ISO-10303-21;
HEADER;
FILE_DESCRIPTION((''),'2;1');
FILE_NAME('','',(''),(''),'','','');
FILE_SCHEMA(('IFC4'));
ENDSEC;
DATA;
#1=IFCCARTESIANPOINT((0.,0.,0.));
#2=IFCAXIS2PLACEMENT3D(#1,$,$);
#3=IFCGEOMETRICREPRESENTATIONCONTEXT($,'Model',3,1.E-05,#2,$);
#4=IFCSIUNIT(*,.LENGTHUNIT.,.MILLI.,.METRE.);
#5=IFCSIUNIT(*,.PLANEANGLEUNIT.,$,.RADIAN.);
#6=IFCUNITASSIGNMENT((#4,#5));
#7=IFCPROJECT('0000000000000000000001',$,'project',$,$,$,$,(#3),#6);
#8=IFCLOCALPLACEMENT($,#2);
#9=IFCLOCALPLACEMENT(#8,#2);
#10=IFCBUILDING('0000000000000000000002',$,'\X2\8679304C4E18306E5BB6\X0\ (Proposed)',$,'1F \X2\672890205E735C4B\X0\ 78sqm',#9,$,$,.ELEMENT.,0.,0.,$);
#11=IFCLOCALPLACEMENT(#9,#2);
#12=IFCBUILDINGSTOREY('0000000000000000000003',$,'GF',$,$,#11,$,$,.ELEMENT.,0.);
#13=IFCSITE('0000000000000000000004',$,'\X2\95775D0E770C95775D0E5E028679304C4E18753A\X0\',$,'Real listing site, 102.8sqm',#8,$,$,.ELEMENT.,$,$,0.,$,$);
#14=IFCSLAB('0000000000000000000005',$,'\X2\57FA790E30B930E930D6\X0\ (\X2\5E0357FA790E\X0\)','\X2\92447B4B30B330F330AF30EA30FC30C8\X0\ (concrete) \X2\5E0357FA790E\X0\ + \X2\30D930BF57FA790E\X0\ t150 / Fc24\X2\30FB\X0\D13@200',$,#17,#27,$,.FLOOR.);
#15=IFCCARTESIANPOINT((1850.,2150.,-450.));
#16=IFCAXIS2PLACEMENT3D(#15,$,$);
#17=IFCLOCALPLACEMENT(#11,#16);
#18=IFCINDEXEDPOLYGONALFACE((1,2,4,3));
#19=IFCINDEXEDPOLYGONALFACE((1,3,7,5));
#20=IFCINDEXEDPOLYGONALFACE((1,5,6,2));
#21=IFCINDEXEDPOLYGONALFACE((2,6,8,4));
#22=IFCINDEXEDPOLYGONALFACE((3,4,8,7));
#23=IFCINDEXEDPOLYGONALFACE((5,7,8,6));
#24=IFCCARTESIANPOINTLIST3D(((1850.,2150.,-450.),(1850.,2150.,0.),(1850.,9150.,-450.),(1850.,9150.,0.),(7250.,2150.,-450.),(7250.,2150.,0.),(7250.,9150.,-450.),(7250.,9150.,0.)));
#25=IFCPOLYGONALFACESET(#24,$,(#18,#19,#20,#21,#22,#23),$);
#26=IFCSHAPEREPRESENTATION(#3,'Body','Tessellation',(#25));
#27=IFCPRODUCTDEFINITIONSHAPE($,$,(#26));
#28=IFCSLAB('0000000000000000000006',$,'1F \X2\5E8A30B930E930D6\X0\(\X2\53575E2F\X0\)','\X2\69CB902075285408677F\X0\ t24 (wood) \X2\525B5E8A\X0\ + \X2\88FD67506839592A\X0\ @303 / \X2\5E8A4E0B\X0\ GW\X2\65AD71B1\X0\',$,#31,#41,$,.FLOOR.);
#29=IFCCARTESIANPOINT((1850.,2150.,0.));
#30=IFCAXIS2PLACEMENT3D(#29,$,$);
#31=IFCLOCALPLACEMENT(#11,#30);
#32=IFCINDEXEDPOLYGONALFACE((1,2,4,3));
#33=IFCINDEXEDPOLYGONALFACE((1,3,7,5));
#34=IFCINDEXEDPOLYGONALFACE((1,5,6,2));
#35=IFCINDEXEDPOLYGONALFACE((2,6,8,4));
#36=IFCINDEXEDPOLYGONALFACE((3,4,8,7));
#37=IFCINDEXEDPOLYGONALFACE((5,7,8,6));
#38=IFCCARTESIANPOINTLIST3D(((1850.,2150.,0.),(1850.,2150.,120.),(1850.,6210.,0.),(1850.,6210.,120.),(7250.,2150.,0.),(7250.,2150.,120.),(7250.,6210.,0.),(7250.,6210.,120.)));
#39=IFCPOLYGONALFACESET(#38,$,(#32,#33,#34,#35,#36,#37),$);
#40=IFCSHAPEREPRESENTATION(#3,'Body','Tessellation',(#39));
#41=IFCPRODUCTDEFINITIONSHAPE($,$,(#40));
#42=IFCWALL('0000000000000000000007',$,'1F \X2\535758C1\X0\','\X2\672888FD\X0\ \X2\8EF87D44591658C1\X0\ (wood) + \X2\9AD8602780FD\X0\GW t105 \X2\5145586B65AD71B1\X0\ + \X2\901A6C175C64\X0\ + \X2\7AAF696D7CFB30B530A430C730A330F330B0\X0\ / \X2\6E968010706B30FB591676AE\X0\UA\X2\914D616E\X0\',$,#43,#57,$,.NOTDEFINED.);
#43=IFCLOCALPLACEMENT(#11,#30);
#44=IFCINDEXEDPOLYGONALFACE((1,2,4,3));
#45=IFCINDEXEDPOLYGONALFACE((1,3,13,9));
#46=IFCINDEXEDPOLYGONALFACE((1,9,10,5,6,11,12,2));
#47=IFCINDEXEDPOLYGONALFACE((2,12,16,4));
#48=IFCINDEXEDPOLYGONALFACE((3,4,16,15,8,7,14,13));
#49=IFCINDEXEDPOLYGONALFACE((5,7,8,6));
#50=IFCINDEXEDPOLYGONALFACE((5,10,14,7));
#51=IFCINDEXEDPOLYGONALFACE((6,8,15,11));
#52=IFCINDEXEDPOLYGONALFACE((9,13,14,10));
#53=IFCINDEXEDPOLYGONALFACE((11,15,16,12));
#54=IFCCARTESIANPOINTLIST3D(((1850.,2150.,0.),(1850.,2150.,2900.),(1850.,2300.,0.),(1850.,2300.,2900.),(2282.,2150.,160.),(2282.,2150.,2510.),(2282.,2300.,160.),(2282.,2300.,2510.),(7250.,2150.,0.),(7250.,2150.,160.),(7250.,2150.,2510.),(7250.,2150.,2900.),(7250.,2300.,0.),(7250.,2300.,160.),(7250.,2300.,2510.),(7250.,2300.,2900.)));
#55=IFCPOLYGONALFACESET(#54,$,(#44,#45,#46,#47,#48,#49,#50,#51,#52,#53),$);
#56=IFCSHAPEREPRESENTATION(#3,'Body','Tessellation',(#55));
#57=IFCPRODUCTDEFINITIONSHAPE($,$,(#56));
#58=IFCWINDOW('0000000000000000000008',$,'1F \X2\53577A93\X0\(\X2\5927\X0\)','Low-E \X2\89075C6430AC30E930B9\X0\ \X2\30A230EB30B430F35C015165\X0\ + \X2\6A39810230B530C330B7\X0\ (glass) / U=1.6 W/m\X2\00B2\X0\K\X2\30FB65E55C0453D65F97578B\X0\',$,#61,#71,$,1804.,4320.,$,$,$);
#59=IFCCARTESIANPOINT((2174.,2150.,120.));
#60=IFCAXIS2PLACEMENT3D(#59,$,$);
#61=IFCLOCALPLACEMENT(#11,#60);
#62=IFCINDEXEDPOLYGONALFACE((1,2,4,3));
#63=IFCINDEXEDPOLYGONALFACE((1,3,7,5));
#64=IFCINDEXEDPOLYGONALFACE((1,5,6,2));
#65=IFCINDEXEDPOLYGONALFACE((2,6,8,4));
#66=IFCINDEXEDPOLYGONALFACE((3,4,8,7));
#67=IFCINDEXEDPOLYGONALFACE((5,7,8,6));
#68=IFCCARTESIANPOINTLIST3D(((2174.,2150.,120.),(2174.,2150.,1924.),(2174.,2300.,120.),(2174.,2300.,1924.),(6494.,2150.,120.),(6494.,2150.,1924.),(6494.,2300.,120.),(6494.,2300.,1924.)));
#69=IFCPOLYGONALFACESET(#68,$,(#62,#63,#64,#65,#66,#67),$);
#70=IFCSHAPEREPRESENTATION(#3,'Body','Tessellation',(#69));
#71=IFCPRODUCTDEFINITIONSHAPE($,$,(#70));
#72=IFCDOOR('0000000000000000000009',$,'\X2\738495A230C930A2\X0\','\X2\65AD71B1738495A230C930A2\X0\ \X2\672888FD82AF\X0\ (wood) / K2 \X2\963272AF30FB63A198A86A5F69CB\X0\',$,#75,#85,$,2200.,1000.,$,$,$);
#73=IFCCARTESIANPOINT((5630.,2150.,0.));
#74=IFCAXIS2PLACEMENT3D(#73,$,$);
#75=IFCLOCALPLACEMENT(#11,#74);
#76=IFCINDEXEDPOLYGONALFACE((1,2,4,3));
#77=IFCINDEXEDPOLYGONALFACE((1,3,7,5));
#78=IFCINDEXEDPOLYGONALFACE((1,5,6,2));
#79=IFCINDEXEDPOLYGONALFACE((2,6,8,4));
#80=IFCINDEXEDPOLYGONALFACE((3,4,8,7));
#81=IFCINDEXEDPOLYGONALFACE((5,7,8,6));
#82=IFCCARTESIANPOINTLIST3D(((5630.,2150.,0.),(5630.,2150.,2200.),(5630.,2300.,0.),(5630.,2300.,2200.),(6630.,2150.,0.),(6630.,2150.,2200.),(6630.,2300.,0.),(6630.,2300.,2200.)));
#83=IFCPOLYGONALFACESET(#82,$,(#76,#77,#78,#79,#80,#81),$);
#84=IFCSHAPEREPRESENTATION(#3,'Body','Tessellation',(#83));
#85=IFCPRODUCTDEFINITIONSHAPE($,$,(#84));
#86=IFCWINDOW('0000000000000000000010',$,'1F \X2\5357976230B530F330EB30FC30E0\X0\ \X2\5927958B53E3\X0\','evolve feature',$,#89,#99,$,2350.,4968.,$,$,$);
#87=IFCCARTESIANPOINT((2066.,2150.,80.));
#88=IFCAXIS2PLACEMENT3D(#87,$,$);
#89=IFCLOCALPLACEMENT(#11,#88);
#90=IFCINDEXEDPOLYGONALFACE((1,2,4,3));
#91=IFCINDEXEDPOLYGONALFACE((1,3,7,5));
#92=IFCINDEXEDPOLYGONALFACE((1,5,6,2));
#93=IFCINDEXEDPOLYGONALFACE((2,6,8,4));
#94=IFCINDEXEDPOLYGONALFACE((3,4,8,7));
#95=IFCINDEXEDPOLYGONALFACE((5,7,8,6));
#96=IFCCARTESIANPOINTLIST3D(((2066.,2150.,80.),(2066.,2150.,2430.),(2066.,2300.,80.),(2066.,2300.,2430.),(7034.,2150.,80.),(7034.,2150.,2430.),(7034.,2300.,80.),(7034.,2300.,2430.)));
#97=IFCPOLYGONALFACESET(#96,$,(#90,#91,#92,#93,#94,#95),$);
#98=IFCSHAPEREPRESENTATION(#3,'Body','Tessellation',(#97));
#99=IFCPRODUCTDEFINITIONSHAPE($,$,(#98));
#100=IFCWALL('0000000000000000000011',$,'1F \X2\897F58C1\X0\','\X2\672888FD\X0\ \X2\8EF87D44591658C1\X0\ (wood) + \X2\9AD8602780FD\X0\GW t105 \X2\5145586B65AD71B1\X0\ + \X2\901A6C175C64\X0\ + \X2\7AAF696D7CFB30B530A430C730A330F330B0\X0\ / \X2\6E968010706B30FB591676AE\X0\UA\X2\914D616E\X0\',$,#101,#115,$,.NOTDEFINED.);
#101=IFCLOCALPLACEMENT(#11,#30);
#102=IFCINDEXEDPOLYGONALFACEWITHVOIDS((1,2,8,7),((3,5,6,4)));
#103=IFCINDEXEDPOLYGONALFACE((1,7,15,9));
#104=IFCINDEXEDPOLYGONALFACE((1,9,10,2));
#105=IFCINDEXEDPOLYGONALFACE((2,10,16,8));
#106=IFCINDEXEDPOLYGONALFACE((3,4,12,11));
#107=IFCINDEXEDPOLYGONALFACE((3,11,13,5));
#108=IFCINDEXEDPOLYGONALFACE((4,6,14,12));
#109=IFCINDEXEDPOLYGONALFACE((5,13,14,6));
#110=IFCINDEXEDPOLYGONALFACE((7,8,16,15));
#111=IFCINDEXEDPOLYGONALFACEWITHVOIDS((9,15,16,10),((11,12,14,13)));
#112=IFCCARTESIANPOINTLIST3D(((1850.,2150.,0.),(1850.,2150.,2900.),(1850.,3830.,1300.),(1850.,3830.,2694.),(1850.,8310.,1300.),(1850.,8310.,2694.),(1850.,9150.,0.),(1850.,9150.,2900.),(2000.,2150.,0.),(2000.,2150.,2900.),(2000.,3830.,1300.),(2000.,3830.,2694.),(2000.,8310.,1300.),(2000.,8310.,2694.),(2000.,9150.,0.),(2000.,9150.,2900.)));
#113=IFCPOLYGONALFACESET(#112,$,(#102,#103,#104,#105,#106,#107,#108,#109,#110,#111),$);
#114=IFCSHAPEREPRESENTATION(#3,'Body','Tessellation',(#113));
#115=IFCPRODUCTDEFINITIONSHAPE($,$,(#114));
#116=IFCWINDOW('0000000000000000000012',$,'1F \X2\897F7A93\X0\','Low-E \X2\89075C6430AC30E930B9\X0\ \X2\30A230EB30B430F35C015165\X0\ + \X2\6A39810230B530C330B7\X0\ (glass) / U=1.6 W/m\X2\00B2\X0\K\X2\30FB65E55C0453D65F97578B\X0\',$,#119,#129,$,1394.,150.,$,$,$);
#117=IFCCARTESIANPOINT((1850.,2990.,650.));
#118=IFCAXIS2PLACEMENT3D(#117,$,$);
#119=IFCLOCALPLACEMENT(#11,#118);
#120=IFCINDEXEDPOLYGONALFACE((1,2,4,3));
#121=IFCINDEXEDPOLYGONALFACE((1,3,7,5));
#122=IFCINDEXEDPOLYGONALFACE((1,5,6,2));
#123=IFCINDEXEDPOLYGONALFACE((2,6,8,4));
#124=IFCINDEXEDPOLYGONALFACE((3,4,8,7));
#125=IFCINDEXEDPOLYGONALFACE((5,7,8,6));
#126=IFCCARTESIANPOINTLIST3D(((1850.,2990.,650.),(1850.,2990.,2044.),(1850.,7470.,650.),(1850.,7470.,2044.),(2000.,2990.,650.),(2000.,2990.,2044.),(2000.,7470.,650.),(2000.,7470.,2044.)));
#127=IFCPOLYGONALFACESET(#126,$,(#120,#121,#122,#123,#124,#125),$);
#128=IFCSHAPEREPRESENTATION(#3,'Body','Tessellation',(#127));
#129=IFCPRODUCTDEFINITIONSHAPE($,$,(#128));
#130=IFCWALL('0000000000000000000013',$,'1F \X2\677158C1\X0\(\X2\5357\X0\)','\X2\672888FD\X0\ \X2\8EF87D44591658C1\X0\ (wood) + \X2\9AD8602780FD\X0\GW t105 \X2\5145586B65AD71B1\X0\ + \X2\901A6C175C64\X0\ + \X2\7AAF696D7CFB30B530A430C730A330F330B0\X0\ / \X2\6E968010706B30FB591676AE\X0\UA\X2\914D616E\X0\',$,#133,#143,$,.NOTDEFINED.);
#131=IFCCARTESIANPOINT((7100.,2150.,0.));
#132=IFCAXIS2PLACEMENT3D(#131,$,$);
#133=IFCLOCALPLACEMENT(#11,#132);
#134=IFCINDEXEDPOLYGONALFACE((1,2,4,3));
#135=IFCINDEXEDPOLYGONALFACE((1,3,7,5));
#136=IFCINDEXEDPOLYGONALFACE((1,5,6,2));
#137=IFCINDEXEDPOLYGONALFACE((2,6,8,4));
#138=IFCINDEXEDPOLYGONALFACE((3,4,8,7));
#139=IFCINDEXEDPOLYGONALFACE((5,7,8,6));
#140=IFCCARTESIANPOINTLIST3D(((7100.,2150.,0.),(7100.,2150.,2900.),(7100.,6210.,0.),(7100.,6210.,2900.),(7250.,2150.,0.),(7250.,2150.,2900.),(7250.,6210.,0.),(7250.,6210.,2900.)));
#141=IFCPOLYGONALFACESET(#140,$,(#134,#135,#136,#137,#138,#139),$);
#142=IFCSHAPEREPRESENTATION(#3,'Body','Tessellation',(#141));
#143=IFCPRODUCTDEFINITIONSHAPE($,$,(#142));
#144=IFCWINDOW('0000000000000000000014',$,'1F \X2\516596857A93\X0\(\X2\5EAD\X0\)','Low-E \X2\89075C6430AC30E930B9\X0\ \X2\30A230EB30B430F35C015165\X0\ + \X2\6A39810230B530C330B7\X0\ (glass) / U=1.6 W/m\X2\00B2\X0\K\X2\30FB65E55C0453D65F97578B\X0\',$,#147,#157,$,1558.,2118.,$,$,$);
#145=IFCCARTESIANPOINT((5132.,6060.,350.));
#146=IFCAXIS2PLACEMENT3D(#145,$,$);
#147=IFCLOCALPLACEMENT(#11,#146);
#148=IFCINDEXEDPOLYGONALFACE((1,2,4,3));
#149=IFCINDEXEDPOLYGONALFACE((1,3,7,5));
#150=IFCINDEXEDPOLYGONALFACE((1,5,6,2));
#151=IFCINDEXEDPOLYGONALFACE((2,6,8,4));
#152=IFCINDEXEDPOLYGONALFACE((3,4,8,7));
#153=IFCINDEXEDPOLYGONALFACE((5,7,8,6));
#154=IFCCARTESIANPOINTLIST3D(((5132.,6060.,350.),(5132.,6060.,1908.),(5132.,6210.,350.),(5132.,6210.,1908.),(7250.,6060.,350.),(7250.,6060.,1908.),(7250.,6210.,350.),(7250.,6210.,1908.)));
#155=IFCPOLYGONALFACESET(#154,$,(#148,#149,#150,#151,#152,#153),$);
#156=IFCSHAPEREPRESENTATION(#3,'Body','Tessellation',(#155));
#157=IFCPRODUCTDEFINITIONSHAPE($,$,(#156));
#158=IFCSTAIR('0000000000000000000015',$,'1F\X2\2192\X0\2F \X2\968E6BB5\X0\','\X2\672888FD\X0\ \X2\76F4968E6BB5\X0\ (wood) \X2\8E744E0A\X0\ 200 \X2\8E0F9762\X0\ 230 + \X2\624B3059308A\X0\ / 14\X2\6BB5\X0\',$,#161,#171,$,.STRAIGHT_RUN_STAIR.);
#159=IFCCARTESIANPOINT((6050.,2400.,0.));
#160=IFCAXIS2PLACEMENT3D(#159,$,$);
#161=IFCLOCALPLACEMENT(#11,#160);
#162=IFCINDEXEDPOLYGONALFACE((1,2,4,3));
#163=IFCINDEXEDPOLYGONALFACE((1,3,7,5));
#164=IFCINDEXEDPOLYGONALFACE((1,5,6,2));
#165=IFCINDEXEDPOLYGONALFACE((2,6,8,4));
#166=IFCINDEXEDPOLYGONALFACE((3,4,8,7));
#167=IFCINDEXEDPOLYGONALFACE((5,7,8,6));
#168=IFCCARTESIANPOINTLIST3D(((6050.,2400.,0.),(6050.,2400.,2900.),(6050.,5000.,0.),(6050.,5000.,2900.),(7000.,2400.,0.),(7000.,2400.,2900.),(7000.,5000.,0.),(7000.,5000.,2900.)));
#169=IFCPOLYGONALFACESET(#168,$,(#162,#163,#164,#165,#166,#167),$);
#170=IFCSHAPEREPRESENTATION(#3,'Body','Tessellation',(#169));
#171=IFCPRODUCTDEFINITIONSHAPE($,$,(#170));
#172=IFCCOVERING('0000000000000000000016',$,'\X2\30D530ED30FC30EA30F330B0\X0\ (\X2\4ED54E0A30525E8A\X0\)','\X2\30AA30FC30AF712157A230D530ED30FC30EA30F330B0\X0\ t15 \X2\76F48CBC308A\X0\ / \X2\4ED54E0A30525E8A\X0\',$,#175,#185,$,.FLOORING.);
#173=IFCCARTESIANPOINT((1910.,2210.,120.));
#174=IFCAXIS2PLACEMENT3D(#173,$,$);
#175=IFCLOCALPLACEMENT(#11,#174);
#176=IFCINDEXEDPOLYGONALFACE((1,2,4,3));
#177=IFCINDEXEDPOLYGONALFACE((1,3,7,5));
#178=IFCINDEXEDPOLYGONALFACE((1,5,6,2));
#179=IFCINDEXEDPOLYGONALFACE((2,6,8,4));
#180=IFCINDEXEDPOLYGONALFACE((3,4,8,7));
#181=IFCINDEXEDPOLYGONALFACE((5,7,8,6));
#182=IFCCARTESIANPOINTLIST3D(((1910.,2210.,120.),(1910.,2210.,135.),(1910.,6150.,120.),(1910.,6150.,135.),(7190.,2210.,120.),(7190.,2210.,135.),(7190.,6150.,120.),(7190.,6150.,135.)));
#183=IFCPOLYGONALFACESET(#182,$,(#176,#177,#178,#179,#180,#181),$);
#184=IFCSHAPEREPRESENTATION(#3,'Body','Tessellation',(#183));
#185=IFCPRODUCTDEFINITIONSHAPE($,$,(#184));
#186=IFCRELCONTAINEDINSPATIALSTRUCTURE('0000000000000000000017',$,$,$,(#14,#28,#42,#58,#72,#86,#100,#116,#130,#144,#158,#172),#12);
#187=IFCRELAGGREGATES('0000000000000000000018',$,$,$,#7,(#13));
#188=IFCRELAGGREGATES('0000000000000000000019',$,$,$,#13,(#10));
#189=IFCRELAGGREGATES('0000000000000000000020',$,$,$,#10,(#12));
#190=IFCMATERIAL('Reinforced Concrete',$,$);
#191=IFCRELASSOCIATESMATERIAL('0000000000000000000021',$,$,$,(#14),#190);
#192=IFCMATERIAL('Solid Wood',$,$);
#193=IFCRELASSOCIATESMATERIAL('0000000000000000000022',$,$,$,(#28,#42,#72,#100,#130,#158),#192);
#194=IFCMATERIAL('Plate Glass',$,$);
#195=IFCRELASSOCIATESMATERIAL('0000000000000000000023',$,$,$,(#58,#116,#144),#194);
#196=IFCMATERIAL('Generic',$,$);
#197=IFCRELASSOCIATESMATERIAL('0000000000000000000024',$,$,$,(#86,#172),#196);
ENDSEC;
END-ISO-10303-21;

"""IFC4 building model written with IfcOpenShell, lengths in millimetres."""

from ifc_helpers import new_model, si_unit, frame, frame_2d, origin, place, context, project, spatial, rectangle, extrude, material, element, fill, save


model = new_model("IFC4")

# Units and contexts
model_context = context("Model", 3, precision=1e-05, world=origin())
ifc_project = project(units=[si_unit("LENGTHUNIT", "METRE", prefix="MILLI"), si_unit("PLANEANGLEUNIT", "RADIAN")], contexts=[model_context])

# Site, building, storey
site_placement = place(None, origin())
site = spatial("IfcSite", under=ifc_project, at=site_placement, Name="長崎県長崎市虹が丘町", ObjectType="Real listing site, 102.8sqm", CompositionType="ELEMENT", RefElevation=0.0)
building_placement = place(site_placement, origin())
building = spatial("IfcBuilding", under=site, at=building_placement, Name="虹が丘の家 (Proposed)", ObjectType="1F 木造平屋 78sqm", CompositionType="ELEMENT", ElevationOfRefHeight=0.0, ElevationOfTerrain=0.0)
storey_placement = place(building_placement, origin())
storey = spatial("IfcBuildingStorey", under=building, at=storey_placement, Name="GF", CompositionType="ELEMENT", Elevation=0.0)

# Slabs
ifc_material_1 = material(Name="Reinforced Concrete")
slab_1_placement = place(storey_placement, frame((1850.0, 2150.0, -450.0)))
element("IfcSlab", 1, at=slab_1_placement, inside=storey, material=ifc_material_1, Name="基礎スラブ (布基礎)", Description="鉄筋コンクリート (concrete) 布基礎 + ベタ基礎 t150 / Fc24・D13@200", PredefinedType="FLOOR", context=model_context, shape_type="SweptSolid", body=[
    extrude(rectangle(XDim=5400.0, YDim=7000.0, at=frame_2d((2700.0, 3500.0))), frame((1850.0, 2150.0, -450.0)), (0.0, 0.0, 1.0), 450.0),
])
ifc_material_2 = material(Name="Solid Wood")
slab_2_placement = place(storey_placement, frame((1850.0, 2150.0, 0.0)))
element("IfcSlab", 2, at=slab_2_placement, inside=storey, material=ifc_material_2, Name="1F 床スラブ(南帯)", Description="構造用合板 t24 (wood) 剛床 + 製材根太 @303 / 床下 GW断熱", PredefinedType="FLOOR", context=model_context, shape_type="SweptSolid", body=[
    extrude(rectangle(XDim=5400.0, YDim=4060.0, at=frame_2d((2700.0, 2030.0))), frame((1850.0, 2150.0, 0.0)), (0.0, 0.0, 1.0), 120.0),
])

# Wall, openings, windows, door
wall_1_placement = place(storey_placement, frame((1850.0, 2150.0, 0.0)))
wall_1 = element("IfcWall", 3, at=wall_1_placement, inside=storey, material=ifc_material_2, Name="1F 南壁", Description="木製 軸組外壁 (wood) + 高性能GW t105 充填断熱 + 通気層 + 窯業系サイディング / 準耐火・外皮UA配慮", PredefinedType="NOTDEFINED", context=model_context, shape_type="SweptSolid", body=[
    extrude(rectangle(XDim=5400.0, YDim=150.0, at=frame_2d((2700.0, 75.0))), frame((1850.0, 2150.0, 0.0)), (0.0, 0.0, 1.0), 2900.0),
])
opening_1_placement = place(storey_placement, frame((2174.0, 2150.0, 120.0)))
opening_1 = element("IfcOpeningElement", 4, at=opening_1_placement, cuts=wall_1, PredefinedType="NOTDEFINED", context=model_context, shape_type="SweptSolid", body=[
    extrude(rectangle(XDim=4320.0, YDim=150.0, at=frame_2d((2160.0, 75.0))), frame((2174.0, 2150.0, 120.0)), (0.0, 0.0, 1.0), 1804.0),
])
opening_2_placement = place(storey_placement, frame((5630.0, 2150.0, 0.0)))
opening_2 = element("IfcOpeningElement", 5, at=opening_2_placement, cuts=wall_1, PredefinedType="NOTDEFINED", context=model_context, shape_type="SweptSolid", body=[
    extrude(rectangle(XDim=1000.0, YDim=150.0, at=frame_2d((500.0, 75.0))), frame((5630.0, 2150.0, 0.0)), (0.0, 0.0, 1.0), 2200.0),
])
opening_3_placement = place(storey_placement, frame((2066.0, 2150.0, 80.0)))
opening_3 = element("IfcOpeningElement", 6, at=opening_3_placement, cuts=wall_1, PredefinedType="NOTDEFINED", context=model_context, shape_type="SweptSolid", body=[
    extrude(rectangle(XDim=4968.0, YDim=150.0, at=frame_2d((2484.0, 75.0))), frame((2066.0, 2150.0, 80.0)), (0.0, 0.0, 1.0), 2350.0),
])
ifc_material_3 = material(Name="Plate Glass")
window_1_placement = place(storey_placement, frame((2174.0, 2150.0, 120.0)))
window_1 = element("IfcWindow", 7, at=window_1_placement, inside=storey, material=ifc_material_3, Name="1F 南窓(大)", Description="Low-E 複層ガラス アルゴン封入 + 樹脂サッシ (glass) / U=1.6 W/m²K・日射取得型", OverallHeight=1804.0, OverallWidth=4320.0, context=model_context, shape_type="SweptSolid", body=[
    extrude(rectangle(XDim=4320.0, YDim=150.0, at=frame_2d((2160.0, 75.0))), frame((2174.0, 2150.0, 120.0)), (0.0, 0.0, 1.0), 1804.0),
])
fill(opening_1, window_1)
door_1_placement = place(storey_placement, frame((5630.0, 2150.0, 0.0)))
door_1 = element("IfcDoor", 8, at=door_1_placement, inside=storey, material=ifc_material_2, Name="玄関ドア", Description="断熱玄関ドア 木製芯 (wood) / K2 防犯・採風機構", OverallHeight=2200.0, OverallWidth=1000.0, context=model_context, shape_type="SweptSolid", body=[
    extrude(rectangle(XDim=1000.0, YDim=150.0, at=frame_2d((500.0, 75.0))), frame((5630.0, 2150.0, 0.0)), (0.0, 0.0, 1.0), 2200.0),
])
fill(opening_2, door_1)
ifc_material_4 = material(Name="Generic")
window_2_placement = place(storey_placement, frame((2066.0, 2150.0, 80.0)))
window_2 = element("IfcWindow", 9, at=window_2_placement, inside=storey, material=ifc_material_4, Name="1F 南面サンルーム 大開口", Description="evolve feature", OverallHeight=2350.0, OverallWidth=4968.0, context=model_context, shape_type="SweptSolid", body=[
    extrude(rectangle(XDim=4968.0, YDim=150.0, at=frame_2d((2484.0, 75.0))), frame((2066.0, 2150.0, 80.0)), (0.0, 0.0, 1.0), 2350.0),
])
fill(opening_3, window_2)

# Walls, openings, windows
wall_2_placement = place(storey_placement, frame((1850.0, 2150.0, 0.0)))
wall_2 = element("IfcWall", 10, at=wall_2_placement, inside=storey, material=ifc_material_2, Name="1F 西壁", Description="木製 軸組外壁 (wood) + 高性能GW t105 充填断熱 + 通気層 + 窯業系サイディング / 準耐火・外皮UA配慮", PredefinedType="NOTDEFINED", context=model_context, shape_type="SweptSolid", body=[
    extrude(rectangle(XDim=150.0, YDim=7000.0, at=frame_2d((75.0, 3500.0))), frame((1850.0, 2150.0, 0.0)), (0.0, 0.0, 1.0), 2900.0),
])
opening_4_placement = place(storey_placement, frame((1850.0, 2990.0, 650.0)))
opening_4 = element("IfcOpeningElement", 11, at=opening_4_placement, cuts=wall_2, PredefinedType="NOTDEFINED", context=model_context, shape_type="SweptSolid", body=[
    extrude(rectangle(XDim=150.0, YDim=4480.0, at=frame_2d((75.0, 2240.0))), frame((1850.0, 2990.0, 650.0)), (0.0, 0.0, 1.0), 1394.0),
])
window_3_placement = place(storey_placement, frame((1850.0, 2990.0, 650.0)))
window_3 = element("IfcWindow", 12, at=window_3_placement, inside=storey, material=ifc_material_3, Name="1F 西窓", Description="Low-E 複層ガラス アルゴン封入 + 樹脂サッシ (glass) / U=1.6 W/m²K・日射取得型", OverallHeight=1394.0, OverallWidth=150.0, context=model_context, shape_type="SweptSolid", body=[
    extrude(rectangle(XDim=150.0, YDim=4480.0, at=frame_2d((75.0, 2240.0))), frame((1850.0, 2990.0, 650.0)), (0.0, 0.0, 1.0), 1394.0),
])
fill(opening_4, window_3)
wall_3_placement = place(storey_placement, frame((7100.0, 2150.0, 0.0)))
wall_3 = element("IfcWall", 13, at=wall_3_placement, inside=storey, material=ifc_material_2, Name="1F 東壁(南)", Description="木製 軸組外壁 (wood) + 高性能GW t105 充填断熱 + 通気層 + 窯業系サイディング / 準耐火・外皮UA配慮", PredefinedType="NOTDEFINED", context=model_context, shape_type="SweptSolid", body=[
    extrude(rectangle(XDim=150.0, YDim=4060.0, at=frame_2d((75.0, 2030.0))), frame((7100.0, 2150.0, 0.0)), (0.0, 0.0, 1.0), 2900.0),
])
opening_5_placement = place(storey_placement, frame((5132.0, 6060.0, 350.0)))
opening_5 = element("IfcOpeningElement", 14, at=opening_5_placement, cuts=wall_3, PredefinedType="NOTDEFINED", context=model_context, shape_type="SweptSolid", body=[
    extrude(rectangle(XDim=2118.0, YDim=150.0, at=frame_2d((1059.0, 75.0))), frame((5132.0, 6060.0, 350.0)), (0.0, 0.0, 1.0), 1558.0),
])
window_4_placement = place(storey_placement, frame((5132.0, 6060.0, 350.0)))
window_4 = element("IfcWindow", 15, at=window_4_placement, inside=storey, material=ifc_material_3, Name="1F 入隅窓(庭)", Description="Low-E 複層ガラス アルゴン封入 + 樹脂サッシ (glass) / U=1.6 W/m²K・日射取得型", OverallHeight=1558.0, OverallWidth=2118.0, context=model_context, shape_type="SweptSolid", body=[
    extrude(rectangle(XDim=2118.0, YDim=150.0, at=frame_2d((1059.0, 75.0))), frame((5132.0, 6060.0, 350.0)), (0.0, 0.0, 1.0), 1558.0),
])
fill(opening_5, window_4)

# Stair
stair_placement = place(storey_placement, frame((6050.0, 2400.0, 0.0)))
element("IfcStair", 16, at=stair_placement, inside=storey, material=ifc_material_2, Name="1F→2F 階段", Description="木製 直階段 (wood) 蹴上 200 踏面 230 + 手すり / 14段", PredefinedType="STRAIGHT_RUN_STAIR", context=model_context, shape_type="SweptSolid", body=[
    extrude(rectangle(XDim=950.0, YDim=2600.0, at=frame_2d((475.0, 1300.0))), frame((6050.0, 2400.0, 0.0)), (0.0, 0.0, 1.0), 2900.0),
])

# Covering
covering_placement = place(storey_placement, frame((1910.0, 2210.0, 120.0)))
element("IfcCovering", 17, at=covering_placement, inside=storey, material=ifc_material_4, Name="フローリング (仕上げ床)", Description="オーク無垢フローリング t15 直貼り / 仕上げ床", PredefinedType="FLOORING", context=model_context, shape_type="SweptSolid", body=[
    extrude(rectangle(XDim=5280.0, YDim=3940.0, at=frame_2d((2640.0, 1970.0))), frame((1910.0, 2210.0, 120.0)), (0.0, 0.0, 1.0), 15.0),
])

save(model, "model.ifc")
